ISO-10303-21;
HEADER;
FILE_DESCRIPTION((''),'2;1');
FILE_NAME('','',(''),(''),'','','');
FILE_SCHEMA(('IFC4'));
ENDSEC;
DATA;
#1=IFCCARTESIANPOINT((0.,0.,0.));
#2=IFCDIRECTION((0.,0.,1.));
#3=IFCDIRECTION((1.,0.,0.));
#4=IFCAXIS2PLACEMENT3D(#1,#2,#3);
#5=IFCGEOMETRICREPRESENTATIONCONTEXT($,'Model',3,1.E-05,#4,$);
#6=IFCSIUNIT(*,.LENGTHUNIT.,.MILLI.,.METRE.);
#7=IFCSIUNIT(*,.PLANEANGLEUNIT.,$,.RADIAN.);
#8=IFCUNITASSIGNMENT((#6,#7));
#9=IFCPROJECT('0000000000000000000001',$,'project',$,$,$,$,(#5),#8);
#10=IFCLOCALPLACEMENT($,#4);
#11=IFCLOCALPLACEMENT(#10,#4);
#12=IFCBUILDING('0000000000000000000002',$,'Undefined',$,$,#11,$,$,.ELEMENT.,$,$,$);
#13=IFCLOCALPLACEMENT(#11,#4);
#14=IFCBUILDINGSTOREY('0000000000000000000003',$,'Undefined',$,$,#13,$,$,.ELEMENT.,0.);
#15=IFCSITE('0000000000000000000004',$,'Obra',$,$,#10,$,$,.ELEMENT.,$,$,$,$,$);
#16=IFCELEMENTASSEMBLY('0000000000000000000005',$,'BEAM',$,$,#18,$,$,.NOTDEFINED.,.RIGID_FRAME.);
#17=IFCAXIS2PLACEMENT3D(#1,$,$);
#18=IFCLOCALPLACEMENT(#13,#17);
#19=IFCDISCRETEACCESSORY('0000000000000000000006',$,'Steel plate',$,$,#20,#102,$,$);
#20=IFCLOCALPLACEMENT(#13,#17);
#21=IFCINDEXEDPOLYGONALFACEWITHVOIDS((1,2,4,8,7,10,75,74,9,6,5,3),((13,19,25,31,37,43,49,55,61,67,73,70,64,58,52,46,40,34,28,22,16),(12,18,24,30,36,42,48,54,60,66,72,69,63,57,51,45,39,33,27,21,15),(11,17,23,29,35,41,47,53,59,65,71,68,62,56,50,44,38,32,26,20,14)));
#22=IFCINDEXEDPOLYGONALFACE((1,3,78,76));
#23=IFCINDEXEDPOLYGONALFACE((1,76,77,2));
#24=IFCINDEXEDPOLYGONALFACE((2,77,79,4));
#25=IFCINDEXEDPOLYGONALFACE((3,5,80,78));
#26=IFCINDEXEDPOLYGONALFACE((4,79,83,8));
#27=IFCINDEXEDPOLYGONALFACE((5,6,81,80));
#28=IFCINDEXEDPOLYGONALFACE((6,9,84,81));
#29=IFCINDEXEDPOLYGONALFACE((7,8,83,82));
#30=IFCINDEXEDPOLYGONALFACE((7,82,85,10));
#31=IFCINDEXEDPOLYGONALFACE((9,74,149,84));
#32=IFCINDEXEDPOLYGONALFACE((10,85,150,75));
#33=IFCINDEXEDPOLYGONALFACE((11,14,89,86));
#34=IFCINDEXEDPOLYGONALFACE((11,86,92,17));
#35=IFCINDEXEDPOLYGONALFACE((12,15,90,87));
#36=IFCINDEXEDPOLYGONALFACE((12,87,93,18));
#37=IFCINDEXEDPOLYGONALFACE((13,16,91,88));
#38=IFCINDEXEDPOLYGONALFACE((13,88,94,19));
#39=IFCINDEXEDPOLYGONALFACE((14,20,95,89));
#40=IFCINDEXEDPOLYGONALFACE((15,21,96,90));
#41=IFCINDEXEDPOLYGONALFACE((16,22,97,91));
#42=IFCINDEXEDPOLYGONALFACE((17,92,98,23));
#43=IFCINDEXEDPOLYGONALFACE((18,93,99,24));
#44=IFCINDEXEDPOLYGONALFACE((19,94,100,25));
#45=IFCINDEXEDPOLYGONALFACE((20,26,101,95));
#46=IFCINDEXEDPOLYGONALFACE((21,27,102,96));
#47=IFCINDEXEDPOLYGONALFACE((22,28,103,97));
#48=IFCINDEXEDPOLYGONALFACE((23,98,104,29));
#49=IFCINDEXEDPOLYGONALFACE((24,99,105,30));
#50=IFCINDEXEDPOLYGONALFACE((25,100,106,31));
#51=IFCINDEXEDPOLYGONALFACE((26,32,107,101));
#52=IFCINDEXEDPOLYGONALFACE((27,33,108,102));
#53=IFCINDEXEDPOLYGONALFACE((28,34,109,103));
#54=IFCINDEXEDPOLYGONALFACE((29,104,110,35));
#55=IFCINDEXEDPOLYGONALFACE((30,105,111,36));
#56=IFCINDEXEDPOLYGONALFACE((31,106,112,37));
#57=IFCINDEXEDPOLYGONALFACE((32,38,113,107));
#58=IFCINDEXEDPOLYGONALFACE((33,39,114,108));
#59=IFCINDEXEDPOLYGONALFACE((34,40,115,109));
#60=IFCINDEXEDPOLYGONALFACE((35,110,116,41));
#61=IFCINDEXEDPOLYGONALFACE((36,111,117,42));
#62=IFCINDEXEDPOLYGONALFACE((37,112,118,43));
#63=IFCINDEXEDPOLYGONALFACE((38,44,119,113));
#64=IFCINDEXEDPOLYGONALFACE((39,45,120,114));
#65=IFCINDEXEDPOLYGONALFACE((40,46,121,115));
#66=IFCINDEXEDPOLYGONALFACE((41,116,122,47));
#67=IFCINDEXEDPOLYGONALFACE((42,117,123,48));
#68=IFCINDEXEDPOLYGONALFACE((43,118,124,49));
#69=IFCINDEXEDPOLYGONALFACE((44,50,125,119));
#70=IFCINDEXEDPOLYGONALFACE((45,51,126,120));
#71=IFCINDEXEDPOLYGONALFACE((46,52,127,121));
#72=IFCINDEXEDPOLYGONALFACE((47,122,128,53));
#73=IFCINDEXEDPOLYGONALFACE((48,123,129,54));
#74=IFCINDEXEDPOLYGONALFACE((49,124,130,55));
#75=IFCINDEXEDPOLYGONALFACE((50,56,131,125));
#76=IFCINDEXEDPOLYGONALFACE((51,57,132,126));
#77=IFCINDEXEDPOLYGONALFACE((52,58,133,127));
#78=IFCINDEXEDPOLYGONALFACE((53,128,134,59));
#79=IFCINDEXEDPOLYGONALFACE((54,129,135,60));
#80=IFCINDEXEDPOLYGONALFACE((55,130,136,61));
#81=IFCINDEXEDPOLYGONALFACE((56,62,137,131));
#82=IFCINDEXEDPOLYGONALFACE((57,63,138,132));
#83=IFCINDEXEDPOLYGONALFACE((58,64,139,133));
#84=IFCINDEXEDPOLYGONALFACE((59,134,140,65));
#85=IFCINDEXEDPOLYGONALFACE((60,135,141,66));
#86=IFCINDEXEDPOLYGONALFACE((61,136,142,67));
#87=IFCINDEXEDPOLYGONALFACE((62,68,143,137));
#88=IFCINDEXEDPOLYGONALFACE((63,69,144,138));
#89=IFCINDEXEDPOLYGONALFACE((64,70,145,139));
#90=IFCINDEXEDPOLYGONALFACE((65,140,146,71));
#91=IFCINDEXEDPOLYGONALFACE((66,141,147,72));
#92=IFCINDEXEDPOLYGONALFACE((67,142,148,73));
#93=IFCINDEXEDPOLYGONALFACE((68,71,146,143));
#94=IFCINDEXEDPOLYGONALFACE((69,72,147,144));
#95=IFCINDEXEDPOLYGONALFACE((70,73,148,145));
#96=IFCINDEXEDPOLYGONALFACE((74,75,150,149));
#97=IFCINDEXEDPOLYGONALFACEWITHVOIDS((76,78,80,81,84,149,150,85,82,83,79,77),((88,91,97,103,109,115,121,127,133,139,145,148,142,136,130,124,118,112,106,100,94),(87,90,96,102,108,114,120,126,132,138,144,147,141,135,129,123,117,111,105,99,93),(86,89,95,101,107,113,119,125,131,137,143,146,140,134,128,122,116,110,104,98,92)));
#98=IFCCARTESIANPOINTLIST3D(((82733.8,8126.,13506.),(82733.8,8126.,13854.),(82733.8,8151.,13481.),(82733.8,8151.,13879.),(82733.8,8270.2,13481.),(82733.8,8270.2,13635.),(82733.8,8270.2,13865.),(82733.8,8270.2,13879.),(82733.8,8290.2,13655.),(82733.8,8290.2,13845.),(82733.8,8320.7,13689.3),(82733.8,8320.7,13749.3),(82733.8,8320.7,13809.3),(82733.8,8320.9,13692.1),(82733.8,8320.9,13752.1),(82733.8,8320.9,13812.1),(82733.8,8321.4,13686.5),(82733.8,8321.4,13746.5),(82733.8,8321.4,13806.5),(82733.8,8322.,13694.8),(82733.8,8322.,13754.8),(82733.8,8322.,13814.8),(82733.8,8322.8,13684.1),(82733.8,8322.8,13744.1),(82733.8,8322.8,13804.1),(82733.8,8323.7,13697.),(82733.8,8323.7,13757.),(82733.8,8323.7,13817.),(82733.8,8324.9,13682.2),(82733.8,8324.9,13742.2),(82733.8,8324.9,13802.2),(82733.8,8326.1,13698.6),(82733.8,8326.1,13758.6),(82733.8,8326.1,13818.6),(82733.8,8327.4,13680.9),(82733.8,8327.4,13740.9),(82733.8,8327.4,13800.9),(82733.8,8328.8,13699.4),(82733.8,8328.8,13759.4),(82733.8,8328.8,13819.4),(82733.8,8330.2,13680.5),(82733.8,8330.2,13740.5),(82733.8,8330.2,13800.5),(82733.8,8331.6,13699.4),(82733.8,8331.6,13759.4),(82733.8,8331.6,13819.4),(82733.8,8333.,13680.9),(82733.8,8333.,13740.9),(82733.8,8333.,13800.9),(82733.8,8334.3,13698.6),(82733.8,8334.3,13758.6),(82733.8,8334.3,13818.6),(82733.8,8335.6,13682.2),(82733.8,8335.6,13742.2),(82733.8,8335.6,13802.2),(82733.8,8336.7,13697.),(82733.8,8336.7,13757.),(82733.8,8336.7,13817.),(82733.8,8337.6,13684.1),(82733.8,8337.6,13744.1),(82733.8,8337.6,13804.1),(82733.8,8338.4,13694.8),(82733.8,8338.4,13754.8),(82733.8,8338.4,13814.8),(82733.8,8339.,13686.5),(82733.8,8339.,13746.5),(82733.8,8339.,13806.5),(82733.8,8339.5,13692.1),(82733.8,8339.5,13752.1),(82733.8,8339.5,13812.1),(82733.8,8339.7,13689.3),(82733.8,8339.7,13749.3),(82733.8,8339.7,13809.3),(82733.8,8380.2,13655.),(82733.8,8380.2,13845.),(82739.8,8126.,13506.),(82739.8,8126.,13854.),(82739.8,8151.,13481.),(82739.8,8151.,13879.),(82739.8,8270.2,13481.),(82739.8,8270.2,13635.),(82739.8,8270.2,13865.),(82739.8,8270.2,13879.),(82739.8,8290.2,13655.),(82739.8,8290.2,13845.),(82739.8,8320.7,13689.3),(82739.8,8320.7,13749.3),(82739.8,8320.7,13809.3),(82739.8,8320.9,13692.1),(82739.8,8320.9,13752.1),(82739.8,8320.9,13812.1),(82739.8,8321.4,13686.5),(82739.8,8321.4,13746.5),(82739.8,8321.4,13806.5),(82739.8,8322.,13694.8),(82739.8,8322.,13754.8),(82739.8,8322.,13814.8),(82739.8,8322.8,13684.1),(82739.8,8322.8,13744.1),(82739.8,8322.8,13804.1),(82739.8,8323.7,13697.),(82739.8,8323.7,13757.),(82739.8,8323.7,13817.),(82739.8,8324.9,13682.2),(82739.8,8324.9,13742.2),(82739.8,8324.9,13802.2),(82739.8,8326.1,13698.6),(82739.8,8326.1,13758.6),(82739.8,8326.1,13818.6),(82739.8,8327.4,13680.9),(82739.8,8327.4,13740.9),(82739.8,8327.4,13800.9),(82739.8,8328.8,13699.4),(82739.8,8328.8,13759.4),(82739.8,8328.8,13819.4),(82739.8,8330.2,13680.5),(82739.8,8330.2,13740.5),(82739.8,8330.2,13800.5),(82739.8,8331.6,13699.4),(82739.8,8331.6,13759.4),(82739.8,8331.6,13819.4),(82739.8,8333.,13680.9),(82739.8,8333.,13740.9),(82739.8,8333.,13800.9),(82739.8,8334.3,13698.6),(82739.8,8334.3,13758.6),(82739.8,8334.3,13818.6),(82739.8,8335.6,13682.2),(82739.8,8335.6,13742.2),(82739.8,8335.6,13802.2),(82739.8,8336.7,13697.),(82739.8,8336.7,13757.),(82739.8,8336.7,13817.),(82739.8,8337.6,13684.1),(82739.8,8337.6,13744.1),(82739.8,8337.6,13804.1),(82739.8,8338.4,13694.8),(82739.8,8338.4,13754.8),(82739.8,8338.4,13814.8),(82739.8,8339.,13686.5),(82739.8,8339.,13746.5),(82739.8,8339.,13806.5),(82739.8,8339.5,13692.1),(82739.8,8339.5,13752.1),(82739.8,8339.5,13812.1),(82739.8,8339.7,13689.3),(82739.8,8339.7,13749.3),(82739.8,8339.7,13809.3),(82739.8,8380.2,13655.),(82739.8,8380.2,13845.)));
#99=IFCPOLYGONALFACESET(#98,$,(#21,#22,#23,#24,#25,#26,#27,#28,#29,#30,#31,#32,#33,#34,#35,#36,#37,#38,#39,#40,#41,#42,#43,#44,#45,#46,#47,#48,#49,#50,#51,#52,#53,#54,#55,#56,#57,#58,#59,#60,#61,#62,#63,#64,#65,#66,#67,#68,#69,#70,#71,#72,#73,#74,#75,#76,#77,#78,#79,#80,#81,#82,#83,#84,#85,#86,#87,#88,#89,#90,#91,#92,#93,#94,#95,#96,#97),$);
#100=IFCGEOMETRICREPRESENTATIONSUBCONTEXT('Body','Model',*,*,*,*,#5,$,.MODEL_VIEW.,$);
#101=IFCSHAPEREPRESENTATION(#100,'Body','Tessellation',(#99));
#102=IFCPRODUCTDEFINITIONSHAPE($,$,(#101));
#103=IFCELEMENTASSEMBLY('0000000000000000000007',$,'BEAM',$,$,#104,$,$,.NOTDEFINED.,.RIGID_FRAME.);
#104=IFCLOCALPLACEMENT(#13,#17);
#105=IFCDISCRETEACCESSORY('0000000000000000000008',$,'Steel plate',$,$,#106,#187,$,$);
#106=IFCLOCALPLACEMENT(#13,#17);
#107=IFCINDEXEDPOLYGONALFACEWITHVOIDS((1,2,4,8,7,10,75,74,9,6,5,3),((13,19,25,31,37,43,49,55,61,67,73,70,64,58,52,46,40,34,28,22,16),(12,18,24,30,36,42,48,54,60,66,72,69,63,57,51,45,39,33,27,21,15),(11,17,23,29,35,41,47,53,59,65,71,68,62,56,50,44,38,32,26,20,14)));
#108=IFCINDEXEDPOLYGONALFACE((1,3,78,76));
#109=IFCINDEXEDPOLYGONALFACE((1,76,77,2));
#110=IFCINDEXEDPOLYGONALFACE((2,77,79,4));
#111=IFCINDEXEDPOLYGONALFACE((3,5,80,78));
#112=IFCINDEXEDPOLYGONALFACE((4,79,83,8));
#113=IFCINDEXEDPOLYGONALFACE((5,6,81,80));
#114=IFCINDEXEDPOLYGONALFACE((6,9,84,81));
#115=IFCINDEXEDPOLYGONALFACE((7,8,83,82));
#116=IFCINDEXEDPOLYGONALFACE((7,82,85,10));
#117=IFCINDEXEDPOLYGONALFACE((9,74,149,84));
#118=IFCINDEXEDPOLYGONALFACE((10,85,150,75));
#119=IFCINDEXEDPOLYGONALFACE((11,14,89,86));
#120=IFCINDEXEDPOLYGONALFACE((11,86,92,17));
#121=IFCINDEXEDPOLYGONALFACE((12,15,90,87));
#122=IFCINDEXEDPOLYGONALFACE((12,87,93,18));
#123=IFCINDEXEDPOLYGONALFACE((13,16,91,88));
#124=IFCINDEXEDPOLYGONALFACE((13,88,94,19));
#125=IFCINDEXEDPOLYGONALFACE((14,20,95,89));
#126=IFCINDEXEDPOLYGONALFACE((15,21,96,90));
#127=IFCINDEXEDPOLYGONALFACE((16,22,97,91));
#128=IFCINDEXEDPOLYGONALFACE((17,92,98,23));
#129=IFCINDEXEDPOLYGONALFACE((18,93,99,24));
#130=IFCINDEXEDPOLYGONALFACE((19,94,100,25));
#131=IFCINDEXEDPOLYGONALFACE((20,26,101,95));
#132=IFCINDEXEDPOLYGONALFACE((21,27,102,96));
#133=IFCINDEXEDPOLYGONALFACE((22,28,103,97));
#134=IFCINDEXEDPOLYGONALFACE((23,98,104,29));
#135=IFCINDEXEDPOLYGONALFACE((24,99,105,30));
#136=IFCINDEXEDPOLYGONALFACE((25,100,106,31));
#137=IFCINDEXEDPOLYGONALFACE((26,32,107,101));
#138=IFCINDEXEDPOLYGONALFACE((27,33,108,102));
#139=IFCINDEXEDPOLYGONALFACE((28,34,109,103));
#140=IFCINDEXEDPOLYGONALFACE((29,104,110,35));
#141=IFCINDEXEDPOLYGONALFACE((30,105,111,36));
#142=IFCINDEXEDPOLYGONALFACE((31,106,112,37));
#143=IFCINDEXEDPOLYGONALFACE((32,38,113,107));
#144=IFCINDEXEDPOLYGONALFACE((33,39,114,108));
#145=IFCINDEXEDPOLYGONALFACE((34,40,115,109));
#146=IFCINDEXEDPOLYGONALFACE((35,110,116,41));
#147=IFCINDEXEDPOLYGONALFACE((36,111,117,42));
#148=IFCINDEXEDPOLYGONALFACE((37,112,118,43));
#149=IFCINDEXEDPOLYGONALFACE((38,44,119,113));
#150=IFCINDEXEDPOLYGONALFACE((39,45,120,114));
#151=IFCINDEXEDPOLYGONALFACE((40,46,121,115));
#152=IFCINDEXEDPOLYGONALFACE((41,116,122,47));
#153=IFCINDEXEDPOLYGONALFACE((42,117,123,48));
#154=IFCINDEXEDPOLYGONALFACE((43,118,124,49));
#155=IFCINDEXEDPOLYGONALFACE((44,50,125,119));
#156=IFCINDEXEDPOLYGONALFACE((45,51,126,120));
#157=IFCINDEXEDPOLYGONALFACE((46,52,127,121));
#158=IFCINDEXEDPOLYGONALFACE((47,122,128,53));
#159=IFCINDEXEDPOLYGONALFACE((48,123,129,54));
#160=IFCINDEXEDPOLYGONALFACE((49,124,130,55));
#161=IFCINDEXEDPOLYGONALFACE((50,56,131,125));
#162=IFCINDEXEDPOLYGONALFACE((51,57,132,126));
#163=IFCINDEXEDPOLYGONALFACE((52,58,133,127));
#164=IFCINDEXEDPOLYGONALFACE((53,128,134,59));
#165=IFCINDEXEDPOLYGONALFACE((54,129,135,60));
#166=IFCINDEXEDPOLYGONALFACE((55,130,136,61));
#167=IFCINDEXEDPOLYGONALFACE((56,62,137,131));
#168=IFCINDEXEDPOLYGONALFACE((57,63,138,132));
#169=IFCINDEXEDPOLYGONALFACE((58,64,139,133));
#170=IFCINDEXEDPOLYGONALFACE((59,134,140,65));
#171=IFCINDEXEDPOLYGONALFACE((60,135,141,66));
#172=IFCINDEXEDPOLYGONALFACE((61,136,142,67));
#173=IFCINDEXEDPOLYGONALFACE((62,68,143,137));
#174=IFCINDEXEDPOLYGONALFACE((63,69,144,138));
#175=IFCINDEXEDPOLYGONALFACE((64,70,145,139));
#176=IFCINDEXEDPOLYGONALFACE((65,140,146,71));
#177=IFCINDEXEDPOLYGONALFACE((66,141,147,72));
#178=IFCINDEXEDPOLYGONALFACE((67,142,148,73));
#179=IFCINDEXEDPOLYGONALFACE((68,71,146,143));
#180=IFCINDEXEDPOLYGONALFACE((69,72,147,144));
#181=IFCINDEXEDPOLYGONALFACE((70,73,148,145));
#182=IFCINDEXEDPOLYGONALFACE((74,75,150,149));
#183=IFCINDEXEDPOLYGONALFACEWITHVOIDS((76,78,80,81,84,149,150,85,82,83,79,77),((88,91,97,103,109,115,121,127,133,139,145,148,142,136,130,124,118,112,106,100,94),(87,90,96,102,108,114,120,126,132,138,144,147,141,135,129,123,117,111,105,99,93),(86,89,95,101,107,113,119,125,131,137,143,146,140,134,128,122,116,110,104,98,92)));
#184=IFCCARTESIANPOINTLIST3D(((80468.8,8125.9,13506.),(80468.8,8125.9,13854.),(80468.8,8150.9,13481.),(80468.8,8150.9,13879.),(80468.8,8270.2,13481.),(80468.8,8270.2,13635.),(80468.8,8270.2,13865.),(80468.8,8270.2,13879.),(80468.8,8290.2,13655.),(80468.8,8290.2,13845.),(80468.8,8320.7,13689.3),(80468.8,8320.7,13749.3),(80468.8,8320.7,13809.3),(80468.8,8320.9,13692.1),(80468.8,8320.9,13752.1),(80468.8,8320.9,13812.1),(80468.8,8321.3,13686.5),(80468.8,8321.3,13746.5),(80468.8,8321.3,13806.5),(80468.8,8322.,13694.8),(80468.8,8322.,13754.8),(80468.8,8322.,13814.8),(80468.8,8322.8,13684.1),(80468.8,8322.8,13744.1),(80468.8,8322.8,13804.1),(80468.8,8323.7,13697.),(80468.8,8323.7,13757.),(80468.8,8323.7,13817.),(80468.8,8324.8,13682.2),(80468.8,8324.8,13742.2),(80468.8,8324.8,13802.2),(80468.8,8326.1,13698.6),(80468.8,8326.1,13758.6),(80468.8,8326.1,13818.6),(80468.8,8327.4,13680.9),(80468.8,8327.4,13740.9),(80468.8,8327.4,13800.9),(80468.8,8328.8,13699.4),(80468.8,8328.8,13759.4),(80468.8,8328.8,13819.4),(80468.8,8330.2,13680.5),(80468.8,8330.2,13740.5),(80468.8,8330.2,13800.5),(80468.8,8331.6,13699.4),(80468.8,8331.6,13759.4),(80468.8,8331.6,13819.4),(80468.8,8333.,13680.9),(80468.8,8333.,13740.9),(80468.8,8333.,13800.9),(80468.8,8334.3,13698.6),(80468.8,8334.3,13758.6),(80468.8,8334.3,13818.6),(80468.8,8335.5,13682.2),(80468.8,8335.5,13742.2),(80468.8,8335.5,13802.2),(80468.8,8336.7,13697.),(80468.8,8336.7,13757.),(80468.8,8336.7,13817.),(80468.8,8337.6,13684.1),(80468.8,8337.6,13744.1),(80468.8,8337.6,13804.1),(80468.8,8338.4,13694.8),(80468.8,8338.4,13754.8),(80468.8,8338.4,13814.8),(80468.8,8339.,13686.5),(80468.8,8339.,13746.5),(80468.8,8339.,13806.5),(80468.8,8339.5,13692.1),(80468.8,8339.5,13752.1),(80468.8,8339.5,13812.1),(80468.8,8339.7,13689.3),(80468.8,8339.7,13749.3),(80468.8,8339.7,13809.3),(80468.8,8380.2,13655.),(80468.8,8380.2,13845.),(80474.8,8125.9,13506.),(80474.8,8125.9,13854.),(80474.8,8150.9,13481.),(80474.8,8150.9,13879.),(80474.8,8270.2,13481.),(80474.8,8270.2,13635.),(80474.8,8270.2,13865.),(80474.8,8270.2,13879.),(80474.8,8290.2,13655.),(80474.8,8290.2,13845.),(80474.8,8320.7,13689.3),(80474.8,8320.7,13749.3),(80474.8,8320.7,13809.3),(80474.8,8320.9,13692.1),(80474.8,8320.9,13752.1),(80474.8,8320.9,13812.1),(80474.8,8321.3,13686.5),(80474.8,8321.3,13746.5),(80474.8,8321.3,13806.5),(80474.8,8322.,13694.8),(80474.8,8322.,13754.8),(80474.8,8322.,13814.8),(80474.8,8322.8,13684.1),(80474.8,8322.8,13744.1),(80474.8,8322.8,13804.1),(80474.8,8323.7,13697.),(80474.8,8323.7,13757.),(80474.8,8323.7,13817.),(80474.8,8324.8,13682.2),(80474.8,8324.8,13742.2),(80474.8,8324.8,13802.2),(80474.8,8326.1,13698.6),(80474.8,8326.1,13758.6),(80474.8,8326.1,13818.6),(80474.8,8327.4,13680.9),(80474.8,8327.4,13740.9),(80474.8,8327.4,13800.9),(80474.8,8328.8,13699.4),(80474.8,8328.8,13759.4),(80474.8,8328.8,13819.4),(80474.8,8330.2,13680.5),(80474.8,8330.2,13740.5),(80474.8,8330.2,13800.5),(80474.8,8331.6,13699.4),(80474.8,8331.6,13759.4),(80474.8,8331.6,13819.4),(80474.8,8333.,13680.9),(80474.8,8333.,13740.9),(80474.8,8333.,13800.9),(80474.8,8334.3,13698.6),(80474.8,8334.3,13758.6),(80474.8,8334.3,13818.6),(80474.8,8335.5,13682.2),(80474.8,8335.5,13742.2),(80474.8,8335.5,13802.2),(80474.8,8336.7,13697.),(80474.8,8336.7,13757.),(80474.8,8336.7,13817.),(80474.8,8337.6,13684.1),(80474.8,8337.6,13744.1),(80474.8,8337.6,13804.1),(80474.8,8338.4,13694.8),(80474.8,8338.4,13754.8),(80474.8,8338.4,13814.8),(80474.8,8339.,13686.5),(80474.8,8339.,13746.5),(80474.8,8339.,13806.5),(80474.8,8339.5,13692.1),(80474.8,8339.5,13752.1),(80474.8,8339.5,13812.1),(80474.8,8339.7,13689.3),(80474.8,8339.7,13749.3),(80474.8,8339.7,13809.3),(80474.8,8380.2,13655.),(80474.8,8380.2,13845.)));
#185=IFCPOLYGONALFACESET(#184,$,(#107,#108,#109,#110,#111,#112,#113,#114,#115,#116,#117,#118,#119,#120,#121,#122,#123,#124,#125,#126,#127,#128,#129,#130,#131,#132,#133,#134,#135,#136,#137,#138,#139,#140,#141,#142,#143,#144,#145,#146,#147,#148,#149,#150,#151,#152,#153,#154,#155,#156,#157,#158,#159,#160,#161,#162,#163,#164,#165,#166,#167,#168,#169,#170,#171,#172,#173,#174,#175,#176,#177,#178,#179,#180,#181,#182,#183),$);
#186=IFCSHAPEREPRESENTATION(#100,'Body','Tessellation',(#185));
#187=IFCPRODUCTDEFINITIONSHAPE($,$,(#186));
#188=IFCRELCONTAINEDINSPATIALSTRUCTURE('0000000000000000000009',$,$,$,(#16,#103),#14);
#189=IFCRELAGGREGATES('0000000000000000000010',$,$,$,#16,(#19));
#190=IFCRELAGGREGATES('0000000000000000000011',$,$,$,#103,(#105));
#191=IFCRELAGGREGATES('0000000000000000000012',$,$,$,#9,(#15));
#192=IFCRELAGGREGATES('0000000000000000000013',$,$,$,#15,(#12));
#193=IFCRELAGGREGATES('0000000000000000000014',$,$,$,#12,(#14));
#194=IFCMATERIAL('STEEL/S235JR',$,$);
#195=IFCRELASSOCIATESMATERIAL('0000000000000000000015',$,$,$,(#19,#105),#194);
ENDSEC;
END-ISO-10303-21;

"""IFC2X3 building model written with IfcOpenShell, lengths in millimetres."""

from ifc_helpers import new_model, si_unit, frame, origin_with_axes, origin_2d_with_axis, place, context, subcontext, project, spatial, polyline, circle, outline, extrude, source, transform, mapped, material, element, aggregate, save


model = new_model("IFC2X3")

# Units and contexts
model_context = context("Model", 3, precision=1e-05, world=origin_with_axes())
body_context = subcontext(model_context, "Body", "Model", "MODEL_VIEW")
ifc_project = project(units=[si_unit("LENGTHUNIT", "METRE", prefix="MILLI"), si_unit("PLANEANGLEUNIT", "RADIAN")], contexts=[model_context])

# Site, building, storey
site_placement = place(None, origin_with_axes())
site = spatial("IfcSite", under=ifc_project, at=site_placement, Name="Obra", CompositionType="ELEMENT")
building_placement = place(site_placement, origin_with_axes())
building = spatial("IfcBuilding", under=site, at=building_placement, Name="Undefined", CompositionType="ELEMENT")
storey_placement = place(building_placement, origin_with_axes())
storey = spatial("IfcBuildingStorey", under=building, at=storey_placement, Name="Undefined", CompositionType="ELEMENT", Elevation=0.0)

# Shared definitions
ifc_material_1 = material(Name="STEEL/S235JR")

# Element assemblies, discrete accessories, openings
assembly_1_placement = place(storey_placement, origin_with_axes())
assembly_1 = element("IfcElementAssembly", 1, at=assembly_1_placement, inside=storey, Name="BEAM", AssemblyPlace="NOTDEFINED", PredefinedType="RIGID_FRAME")
discrete_accessory_1_placement = place(assembly_1_placement, frame((82736.8, 8126.0, 13506.0), z_axis=(1.0, 0.0, 0.0), x_axis=(-0.000001, 0.707107, -0.707107)))
discrete_accessory_1 = element("IfcDiscreteAccessory", 2, at=discrete_accessory_1_placement, material=ifc_material_1, Name="Steel plate", context=body_context, shape_type="SweptSolid", body=[
    extrude(outline(polyline([(0.0, 0.0), (35.4, 0.0), (119.7, 84.3), (10.8, 193.2), (10.8, 221.5), (74.4, 285.1), (-59.9, 419.5), (-123.6, 355.9), (-151.9, 355.9), (-161.8, 365.8), (-246.1, 281.4), (-246.1, 246.1), (0.0, 0.0)])), frame((0.0, 0.0, -3.0), z_axis=(0.0, 0.0, 1.0), x_axis=(1.0, 0.0, 0.0)), (0.0, 0.0, 1.0), 6.0),
])
shared_shape_1 = source(origin_with_axes(), body_context, "Body", "SweptSolid", [
    extrude(circle(Radius=9.5, at=origin_2d_with_axis()), frame((0.0, -9.6, 0.0), z_axis=(0.0, 1.0, 0.0), x_axis=(1.0, 0.0, 0.0)), (0.0, 0.0, 1.0), 6.2),
])
opening_1_placement = place(assembly_1_placement, frame((82730.3, 8280.2, 13845.0), z_axis=(0.0, 1.0, 0.0), x_axis=(0.0, 0.0, -1.0)))
element("IfcOpeningElement", 3, at=opening_1_placement, cuts=discrete_accessory_1, ObjectType="Opening", context=body_context, shape_type="MappedRepresentation", body=[
    mapped(shared_shape_1, transform((35.0, 0.0, 50.0))),
    mapped(shared_shape_1, transform((95.0, 0.0, 50.0))),
    mapped(shared_shape_1, transform((155.0, 0.0, 50.0))),
])
aggregate(assembly_1, [discrete_accessory_1])
assembly_2_placement = place(storey_placement, origin_with_axes())
assembly_2 = element("IfcElementAssembly", 4, at=assembly_2_placement, inside=storey, Name="BEAM", AssemblyPlace="NOTDEFINED", PredefinedType="RIGID_FRAME")
discrete_accessory_2_placement = place(assembly_2_placement, frame((80471.8, 8125.9, 13506.0), z_axis=(1.0, 0.000014, 0.0), x_axis=(-0.00001, 0.707107, -0.707107)))
discrete_accessory_2 = element("IfcDiscreteAccessory", 5, at=discrete_accessory_2_placement, material=ifc_material_1, Name="Steel plate", context=body_context, shape_type="SweptSolid", body=[
    extrude(outline(polyline([(0.0, 0.0), (35.4, 0.0), (119.7, 84.3), (10.8, 193.2), (10.8, 221.5), (74.4, 285.1), (-59.9, 419.5), (-123.6, 355.9), (-151.9, 355.9), (-161.8, 365.8), (-246.1, 281.4), (-246.1, 246.1), (0.0, 0.0)])), frame((0.0, 0.0, -3.0), z_axis=(0.0, 0.0, 1.0), x_axis=(1.0, 0.0, 0.0)), (0.0, 0.0, 1.0), 6.0),
])
shared_shape_2 = source(origin_with_axes(), body_context, "Body", "SweptSolid", [
    extrude(circle(Radius=9.5, at=origin_2d_with_axis()), frame((0.0, -9.7, 0.0), z_axis=(0.0, 1.0, 0.0), x_axis=(1.0, 0.0, 0.0)), (0.0, 0.0, 1.0), 6.2),
])
opening_2_placement = place(assembly_2_placement, frame((80465.3, 8280.2, 13845.0), z_axis=(-0.000014, 1.0, 0.0), x_axis=(0.0, 0.0, -1.0)))
element("IfcOpeningElement", 6, at=opening_2_placement, cuts=discrete_accessory_2, ObjectType="Opening", context=body_context, shape_type="MappedRepresentation", body=[
    mapped(shared_shape_2, transform((35.0, 0.0, 50.0))),
    mapped(shared_shape_2, transform((95.0, 0.0, 50.0))),
    mapped(shared_shape_2, transform((155.0, 0.0, 50.0))),
])
aggregate(assembly_2, [discrete_accessory_2])

save(model, "model.ifc")
